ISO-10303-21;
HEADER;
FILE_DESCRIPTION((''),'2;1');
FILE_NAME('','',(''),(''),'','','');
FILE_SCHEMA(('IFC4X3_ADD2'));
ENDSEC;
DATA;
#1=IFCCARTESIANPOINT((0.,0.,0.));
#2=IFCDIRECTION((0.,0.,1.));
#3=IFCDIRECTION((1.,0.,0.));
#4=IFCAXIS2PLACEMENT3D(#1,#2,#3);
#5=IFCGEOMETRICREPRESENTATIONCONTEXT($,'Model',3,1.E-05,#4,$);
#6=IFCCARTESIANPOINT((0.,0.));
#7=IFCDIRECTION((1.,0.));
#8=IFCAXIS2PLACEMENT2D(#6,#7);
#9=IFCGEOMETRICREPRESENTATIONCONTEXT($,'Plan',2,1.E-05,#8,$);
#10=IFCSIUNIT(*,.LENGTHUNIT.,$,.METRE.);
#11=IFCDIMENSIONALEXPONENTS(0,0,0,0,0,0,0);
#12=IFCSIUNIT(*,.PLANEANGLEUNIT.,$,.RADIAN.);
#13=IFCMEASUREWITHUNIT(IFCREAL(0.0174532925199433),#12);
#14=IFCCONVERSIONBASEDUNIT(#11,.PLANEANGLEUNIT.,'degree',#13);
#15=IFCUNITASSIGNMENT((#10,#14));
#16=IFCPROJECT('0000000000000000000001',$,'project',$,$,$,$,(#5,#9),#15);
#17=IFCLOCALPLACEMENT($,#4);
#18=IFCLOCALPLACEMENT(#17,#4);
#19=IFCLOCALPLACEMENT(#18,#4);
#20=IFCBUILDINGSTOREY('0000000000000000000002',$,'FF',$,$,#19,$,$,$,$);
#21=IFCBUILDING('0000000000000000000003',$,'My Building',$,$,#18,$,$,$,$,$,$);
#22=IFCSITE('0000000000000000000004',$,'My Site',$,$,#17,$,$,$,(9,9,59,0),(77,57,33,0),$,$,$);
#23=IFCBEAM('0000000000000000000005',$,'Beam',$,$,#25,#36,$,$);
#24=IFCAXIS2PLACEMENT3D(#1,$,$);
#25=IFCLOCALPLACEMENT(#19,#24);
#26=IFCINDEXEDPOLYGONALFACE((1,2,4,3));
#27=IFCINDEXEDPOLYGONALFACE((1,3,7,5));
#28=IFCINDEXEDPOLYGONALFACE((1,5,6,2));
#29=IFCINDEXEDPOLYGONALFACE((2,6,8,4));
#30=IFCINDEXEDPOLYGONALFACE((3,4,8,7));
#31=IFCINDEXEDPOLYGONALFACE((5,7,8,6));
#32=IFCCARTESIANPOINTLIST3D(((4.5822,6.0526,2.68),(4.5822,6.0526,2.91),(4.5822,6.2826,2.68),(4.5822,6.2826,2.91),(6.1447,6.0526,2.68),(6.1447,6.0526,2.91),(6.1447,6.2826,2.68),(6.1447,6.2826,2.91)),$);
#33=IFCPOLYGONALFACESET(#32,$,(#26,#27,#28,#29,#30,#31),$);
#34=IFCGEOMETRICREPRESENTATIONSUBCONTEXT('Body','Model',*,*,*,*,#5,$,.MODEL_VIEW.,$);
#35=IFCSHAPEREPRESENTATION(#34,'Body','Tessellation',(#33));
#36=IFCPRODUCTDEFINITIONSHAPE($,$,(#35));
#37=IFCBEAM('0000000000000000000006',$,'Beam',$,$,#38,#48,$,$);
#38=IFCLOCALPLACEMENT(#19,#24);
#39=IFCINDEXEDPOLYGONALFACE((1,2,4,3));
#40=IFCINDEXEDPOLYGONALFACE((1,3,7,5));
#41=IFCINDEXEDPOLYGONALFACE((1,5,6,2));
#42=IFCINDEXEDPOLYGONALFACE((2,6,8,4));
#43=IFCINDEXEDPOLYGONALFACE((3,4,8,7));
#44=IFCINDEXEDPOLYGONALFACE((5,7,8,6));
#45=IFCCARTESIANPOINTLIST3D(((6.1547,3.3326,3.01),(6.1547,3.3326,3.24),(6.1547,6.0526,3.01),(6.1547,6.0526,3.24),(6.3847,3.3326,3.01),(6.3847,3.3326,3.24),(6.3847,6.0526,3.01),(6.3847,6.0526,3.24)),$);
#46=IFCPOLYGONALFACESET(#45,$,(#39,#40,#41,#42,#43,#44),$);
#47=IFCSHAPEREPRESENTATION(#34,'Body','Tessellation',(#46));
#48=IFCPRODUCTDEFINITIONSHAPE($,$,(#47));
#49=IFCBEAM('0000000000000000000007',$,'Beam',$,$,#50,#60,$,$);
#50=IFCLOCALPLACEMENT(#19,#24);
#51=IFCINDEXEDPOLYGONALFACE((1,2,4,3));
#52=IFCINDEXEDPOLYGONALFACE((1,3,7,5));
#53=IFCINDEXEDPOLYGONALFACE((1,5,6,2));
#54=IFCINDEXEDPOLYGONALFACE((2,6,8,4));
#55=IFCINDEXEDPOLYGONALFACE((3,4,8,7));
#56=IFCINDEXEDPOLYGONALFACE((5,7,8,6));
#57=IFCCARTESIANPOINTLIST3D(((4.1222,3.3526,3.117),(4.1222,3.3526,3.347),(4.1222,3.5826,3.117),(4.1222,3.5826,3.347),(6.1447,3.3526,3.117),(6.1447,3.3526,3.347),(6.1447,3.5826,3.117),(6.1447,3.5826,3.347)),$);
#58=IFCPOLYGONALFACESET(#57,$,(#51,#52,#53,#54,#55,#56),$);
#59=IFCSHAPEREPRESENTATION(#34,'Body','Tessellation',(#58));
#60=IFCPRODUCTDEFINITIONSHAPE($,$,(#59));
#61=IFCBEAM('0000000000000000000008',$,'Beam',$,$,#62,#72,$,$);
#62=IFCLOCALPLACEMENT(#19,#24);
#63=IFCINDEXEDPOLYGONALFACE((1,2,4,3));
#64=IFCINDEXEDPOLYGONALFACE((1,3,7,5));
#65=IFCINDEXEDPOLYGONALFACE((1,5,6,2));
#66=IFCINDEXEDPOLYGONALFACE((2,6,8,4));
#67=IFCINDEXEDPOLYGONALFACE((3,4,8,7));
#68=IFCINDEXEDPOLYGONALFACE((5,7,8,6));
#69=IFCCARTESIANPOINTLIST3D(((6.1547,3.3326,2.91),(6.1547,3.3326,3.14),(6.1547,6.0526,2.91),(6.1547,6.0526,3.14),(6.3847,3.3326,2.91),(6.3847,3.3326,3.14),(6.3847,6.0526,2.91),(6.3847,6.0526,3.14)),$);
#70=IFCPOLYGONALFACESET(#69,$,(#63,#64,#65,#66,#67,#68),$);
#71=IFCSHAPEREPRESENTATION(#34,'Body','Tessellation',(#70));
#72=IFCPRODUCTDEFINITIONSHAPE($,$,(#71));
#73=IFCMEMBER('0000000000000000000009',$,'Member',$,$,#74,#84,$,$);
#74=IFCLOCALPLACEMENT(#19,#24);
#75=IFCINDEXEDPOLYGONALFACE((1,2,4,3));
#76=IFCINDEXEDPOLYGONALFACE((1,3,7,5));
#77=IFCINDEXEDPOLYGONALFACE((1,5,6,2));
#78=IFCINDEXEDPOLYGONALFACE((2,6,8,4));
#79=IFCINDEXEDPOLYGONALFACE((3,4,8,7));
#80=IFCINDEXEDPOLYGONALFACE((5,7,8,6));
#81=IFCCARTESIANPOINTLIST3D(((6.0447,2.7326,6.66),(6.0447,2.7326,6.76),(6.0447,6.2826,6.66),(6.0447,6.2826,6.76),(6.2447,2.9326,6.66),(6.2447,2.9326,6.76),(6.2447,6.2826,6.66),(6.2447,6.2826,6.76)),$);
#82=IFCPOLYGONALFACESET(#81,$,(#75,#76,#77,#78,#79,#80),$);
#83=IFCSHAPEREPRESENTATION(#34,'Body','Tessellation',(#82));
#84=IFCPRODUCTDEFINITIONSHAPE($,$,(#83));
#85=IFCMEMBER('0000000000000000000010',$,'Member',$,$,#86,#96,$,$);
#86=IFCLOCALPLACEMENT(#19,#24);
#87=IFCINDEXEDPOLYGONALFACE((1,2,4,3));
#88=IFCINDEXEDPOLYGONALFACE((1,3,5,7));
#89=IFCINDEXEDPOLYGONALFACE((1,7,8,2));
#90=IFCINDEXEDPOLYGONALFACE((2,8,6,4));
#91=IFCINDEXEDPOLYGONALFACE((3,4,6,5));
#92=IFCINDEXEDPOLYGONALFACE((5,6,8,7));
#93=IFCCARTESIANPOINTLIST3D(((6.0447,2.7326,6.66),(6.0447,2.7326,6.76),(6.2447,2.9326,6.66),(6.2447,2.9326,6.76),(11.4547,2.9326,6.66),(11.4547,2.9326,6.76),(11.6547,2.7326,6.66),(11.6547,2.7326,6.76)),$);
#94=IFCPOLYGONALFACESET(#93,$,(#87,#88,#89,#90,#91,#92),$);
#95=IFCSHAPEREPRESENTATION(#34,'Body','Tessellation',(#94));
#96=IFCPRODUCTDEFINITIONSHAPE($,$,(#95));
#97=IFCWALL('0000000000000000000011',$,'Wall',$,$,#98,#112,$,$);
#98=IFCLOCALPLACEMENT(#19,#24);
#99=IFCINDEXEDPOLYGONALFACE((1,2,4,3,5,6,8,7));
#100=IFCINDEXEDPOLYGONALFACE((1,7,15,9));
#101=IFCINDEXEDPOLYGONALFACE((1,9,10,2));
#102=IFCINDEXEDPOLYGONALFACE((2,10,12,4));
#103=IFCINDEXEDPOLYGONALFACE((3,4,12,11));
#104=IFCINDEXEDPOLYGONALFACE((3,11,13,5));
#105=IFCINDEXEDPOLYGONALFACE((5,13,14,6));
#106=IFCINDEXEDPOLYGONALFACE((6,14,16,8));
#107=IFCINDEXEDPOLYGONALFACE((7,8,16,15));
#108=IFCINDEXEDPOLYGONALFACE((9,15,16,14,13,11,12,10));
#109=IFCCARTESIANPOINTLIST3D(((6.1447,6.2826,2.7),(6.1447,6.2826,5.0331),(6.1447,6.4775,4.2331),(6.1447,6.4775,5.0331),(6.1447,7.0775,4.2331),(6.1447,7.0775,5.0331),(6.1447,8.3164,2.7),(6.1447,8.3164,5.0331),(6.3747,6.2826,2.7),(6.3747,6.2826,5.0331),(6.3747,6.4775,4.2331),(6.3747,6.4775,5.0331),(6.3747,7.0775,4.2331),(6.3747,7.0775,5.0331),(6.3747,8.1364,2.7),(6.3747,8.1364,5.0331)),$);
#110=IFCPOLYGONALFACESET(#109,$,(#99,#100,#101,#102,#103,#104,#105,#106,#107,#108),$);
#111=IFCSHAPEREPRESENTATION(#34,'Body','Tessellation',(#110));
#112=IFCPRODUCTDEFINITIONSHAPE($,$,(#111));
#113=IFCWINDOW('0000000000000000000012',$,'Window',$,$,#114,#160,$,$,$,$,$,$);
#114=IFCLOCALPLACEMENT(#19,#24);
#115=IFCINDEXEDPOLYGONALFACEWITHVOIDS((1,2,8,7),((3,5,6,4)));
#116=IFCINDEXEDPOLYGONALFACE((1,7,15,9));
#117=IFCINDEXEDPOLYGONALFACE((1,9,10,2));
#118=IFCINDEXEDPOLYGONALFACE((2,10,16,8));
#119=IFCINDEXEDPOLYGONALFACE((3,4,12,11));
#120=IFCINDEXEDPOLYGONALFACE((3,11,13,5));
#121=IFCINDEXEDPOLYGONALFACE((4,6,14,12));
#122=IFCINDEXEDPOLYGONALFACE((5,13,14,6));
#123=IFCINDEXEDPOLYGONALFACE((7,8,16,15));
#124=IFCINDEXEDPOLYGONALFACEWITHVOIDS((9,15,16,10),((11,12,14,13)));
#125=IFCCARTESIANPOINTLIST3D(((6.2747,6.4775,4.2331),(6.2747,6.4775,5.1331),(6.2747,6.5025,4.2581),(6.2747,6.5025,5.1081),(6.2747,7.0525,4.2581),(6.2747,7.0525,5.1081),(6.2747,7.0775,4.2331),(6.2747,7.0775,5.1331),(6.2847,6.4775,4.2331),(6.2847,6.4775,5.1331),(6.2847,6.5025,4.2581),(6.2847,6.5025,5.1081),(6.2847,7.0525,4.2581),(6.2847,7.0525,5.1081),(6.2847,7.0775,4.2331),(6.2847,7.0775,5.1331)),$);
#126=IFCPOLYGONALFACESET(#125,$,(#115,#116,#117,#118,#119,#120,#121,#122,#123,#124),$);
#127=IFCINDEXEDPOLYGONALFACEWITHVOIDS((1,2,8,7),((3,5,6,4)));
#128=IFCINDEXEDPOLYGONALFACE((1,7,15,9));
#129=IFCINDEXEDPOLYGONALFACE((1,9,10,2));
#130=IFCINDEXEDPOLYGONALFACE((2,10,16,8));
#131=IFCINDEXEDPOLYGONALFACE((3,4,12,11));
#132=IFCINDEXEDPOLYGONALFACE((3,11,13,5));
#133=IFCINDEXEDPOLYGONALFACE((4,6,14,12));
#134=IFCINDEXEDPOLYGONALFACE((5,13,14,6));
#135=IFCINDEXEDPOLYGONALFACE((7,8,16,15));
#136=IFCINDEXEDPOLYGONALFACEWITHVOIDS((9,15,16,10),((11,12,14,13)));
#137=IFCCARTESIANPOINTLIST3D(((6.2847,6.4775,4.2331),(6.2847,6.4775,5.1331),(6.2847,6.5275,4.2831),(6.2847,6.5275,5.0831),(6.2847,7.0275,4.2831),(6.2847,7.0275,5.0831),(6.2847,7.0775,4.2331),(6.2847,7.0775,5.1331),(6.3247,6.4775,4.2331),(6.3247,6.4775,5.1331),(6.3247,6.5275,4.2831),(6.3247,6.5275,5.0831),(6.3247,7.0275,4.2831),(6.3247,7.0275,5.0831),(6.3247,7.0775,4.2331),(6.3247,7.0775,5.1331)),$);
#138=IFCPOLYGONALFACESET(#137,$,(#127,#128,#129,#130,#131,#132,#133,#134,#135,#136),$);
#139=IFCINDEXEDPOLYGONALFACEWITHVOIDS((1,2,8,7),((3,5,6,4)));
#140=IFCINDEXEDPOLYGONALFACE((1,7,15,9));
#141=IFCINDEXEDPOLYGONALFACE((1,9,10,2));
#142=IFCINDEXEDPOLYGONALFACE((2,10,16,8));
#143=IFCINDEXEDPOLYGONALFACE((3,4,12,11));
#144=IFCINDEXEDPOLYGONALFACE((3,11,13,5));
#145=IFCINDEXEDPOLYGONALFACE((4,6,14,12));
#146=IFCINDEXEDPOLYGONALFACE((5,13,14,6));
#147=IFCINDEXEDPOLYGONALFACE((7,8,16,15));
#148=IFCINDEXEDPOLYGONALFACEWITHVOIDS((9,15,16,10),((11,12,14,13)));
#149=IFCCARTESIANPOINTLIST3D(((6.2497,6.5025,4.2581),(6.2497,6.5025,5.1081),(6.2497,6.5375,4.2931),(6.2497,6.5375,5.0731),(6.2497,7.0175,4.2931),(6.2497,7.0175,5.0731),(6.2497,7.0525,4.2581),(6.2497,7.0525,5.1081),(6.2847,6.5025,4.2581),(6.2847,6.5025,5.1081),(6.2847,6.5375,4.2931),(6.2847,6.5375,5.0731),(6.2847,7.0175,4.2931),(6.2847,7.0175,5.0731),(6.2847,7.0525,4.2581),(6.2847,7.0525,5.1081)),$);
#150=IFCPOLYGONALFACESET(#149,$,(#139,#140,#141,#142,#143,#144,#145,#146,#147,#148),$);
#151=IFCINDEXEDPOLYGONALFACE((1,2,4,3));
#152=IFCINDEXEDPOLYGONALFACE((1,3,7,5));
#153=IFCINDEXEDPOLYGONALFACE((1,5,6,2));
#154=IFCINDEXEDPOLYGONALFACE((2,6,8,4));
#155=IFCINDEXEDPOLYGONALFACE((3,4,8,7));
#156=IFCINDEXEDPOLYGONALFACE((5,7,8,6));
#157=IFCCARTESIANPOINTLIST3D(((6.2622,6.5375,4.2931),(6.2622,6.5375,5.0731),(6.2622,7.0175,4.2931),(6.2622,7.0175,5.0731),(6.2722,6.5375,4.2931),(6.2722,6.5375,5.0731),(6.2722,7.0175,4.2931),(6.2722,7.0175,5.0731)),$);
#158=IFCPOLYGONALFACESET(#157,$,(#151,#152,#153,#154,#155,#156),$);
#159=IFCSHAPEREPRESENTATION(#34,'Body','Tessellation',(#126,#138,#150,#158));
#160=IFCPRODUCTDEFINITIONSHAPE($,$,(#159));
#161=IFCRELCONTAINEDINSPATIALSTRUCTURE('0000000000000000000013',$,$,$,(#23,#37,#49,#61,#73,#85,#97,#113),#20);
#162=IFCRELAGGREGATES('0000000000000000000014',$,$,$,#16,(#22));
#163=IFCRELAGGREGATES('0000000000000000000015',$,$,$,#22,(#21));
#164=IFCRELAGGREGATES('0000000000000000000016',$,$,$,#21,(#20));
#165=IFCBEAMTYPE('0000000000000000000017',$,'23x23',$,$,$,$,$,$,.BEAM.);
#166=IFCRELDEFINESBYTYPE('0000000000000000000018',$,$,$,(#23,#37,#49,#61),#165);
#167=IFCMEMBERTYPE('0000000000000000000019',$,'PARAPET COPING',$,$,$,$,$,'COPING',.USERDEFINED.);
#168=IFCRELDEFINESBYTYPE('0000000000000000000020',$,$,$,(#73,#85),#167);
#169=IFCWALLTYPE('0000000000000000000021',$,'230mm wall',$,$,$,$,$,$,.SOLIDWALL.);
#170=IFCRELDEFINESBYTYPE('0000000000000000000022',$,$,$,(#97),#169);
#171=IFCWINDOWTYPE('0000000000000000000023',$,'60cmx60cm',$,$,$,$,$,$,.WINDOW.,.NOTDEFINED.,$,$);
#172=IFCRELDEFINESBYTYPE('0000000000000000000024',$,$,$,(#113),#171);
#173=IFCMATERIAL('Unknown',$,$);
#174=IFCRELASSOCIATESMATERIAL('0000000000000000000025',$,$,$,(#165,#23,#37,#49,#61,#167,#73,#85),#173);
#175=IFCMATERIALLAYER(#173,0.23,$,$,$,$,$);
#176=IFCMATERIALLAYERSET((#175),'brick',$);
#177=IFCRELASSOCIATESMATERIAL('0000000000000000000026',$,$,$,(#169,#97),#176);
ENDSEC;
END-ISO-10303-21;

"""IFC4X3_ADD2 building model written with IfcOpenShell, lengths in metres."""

from ifc_helpers import new_model, entity, si_unit, converted_unit, frame, origin_with_axes, origin_2d_with_axis, place, context, subcontext, project, spatial, line, indexed_curve, rectangle, outline, extrude, clip, halfspace, shape, source, transform, mapped, material, layer, layer_set, layer_usage, material_profile, profile_set, profile_usage, type_object, type_shapes, element, fill, save


model = new_model("IFC4X3_ADD2")

# Units and contexts
model_context = context("Model", 3, precision=1e-05, world=origin_with_axes())
plan_context = context("Plan", 2, precision=1e-05, world=origin_2d_with_axis())
body_context_1 = subcontext(model_context, "Body", "Model", "MODEL_VIEW")
body_context_2 = subcontext(plan_context, "Body", "Plan", "PLAN_VIEW")
ifc_project = project(units=[si_unit("LENGTHUNIT", "METRE"), converted_unit("PLANEANGLEUNIT", "degree", entity("IfcReal", 0.0174532925199433), si_unit("PLANEANGLEUNIT", "RADIAN"), dimensions=[0, 0, 0, 0, 0, 0, 0])], contexts=[model_context, plan_context])

# Site, building, storey
site_placement = place(None, origin_with_axes())
site = spatial("IfcSite", under=ifc_project, at=site_placement, Name="My Site", RefLatitude=(9, 9, 59, 0), RefLongitude=(77, 57, 33, 0))
building_placement = place(site_placement, origin_with_axes())
building = spatial("IfcBuilding", under=site, at=building_placement, Name="My Building")
storey_placement = place(building_placement, origin_with_axes())
storey = spatial("IfcBuildingStorey", under=building, at=storey_placement, Name="FF")

# Beams
ifc_material_1 = material(Name="Unknown")
ifc_material_profile_1 = material_profile(ifc_material_1, rectangle(XDim=0.23, YDim=0.23))
ifc_profile_set_1 = profile_set([ifc_material_profile_1])
ifc_profile_usage_1 = profile_usage(ifc_profile_set_1, cardinal=5)
beam_type = type_object("IfcBeamType", Name="23x23", PredefinedType="BEAM", material=ifc_profile_set_1)
beam_1_placement = place(storey_placement, frame((6.1447, 6.1676, 2.795), z_axis=(-1.0, 0.0, 0.0), x_axis=(0.0, -1.0, 0.0)))
element("IfcBeam", 1, at=beam_1_placement, inside=storey, type_object=beam_type, material=ifc_profile_usage_1, Name="Beam", context=body_context_1, shape_type="SweptSolid", body=[
    extrude(rectangle(XDim=0.23, YDim=0.23), origin_with_axes(), (0.0, 0.0, 1.0), 1.5625),
])
ifc_profile_usage_2 = profile_usage(ifc_profile_set_1, cardinal=5)
beam_2_placement = place(storey_placement, frame((6.2697, 3.3326, 3.125), z_axis=(0.0, 1.0, 0.0), x_axis=(-1.0, 0.0, 0.0)))
element("IfcBeam", 2, at=beam_2_placement, inside=storey, type_object=beam_type, material=ifc_profile_usage_2, Name="Beam", context=body_context_1, shape_type="SweptSolid", body=[
    extrude(rectangle(XDim=0.23, YDim=0.23), origin_with_axes(), (0.0, 0.0, 1.0), 2.72),
])
ifc_profile_usage_3 = profile_usage(ifc_profile_set_1, cardinal=5)
beam_3_placement = place(storey_placement, frame((6.1447, 3.4676, 3.232), z_axis=(-1.0, 0.0, 0.0), x_axis=(0.0, -1.0, 0.0)))
element("IfcBeam", 3, at=beam_3_placement, inside=storey, type_object=beam_type, material=ifc_profile_usage_3, Name="Beam", context=body_context_1, shape_type="SweptSolid", body=[
    extrude(rectangle(XDim=0.23, YDim=0.23), origin_with_axes(), (0.0, 0.0, 1.0), 2.0225),
])
ifc_profile_usage_4 = profile_usage(ifc_profile_set_1, cardinal=5)
beam_4_placement = place(storey_placement, frame((6.2697, 3.3326, 3.025), z_axis=(0.0, 1.0, 0.0), x_axis=(-1.0, 0.0, 0.0)))
element("IfcBeam", 4, at=beam_4_placement, inside=storey, type_object=beam_type, material=ifc_profile_usage_4, Name="Beam", context=body_context_1, shape_type="SweptSolid", body=[
    extrude(rectangle(XDim=0.23, YDim=0.23), origin_with_axes(), (0.0, 0.0, 1.0), 2.72),
])

# Members
ifc_material_profile_2 = material_profile(ifc_material_1, rectangle(XDim=0.2, YDim=0.1))
ifc_profile_set_2 = profile_set([ifc_material_profile_2])
ifc_profile_usage_5 = profile_usage(ifc_profile_set_2, cardinal=5)
member_type = type_object("IfcMemberType", Name="PARAPET COPING", ElementType="COPING", PredefinedType="USERDEFINED", material=ifc_profile_set_2)
member_1_placement = place(storey_placement, frame((6.1447, 6.2826, 6.71), z_axis=(0.0, -1.0, 0.0), x_axis=(1.0, 0.0, 0.0)))
element("IfcMember", 5, at=member_1_placement, inside=storey, type_object=member_type, material=ifc_profile_usage_5, Name="Member", context=body_context_1, shape_type="Clipping", body=[
    clip(extrude(rectangle(XDim=0.2, YDim=0.1), origin_with_axes(), (0.0, 0.0, 1.0), 3.55), halfspace(frame((-0.1, -6.66, 3.55), z_axis=(0.707107, 0.0, 0.707107), x_axis=(0.0, -1.0, 0.0)), False)),
])
ifc_profile_usage_6 = profile_usage(ifc_profile_set_2, cardinal=5)
member_2_placement = place(storey_placement, frame((6.0447, 2.8326, 6.71), z_axis=(1.0, 0.0, 0.0), x_axis=(0.0, 1.0, 0.0)))
element("IfcMember", 6, at=member_2_placement, inside=storey, type_object=member_type, material=ifc_profile_usage_6, Name="Member", context=body_context_1, shape_type="Clipping", body=[
    clip(clip(extrude(rectangle(XDim=0.2, YDim=0.1), origin_with_axes(), (0.0, 0.0, 1.0), 5.6101), halfspace(frame((-0.1, -6.66, 5.6101), z_axis=(0.707108, 0.0, 0.707105), x_axis=(0.0, -1.0, 0.0)), False)), halfspace(frame((-0.1, -6.66, 0.0), z_axis=(0.707107, 0.0, -0.707107), x_axis=(0.0, -1.0, 0.0)), False)),
])

# Shared definitions
shared_shape_1 = source(origin_with_axes(), body_context_1, "Body", "SweptSolid", [
    extrude(outline(indexed_curve([(0.0, 0.0), (0.6, 0.0), (0.6, 0.9), (0.0, 0.9)], segments=[line(1, 2, 3, 4, 1)])), frame((0.0, -0.6, 0.0), z_axis=(0.0, -1.0, 0.0), x_axis=(1.0, 0.0, 0.0)), (0.0, 0.0, -1.0), 1.2),
])
window_type_1 = type_object("IfcWindowType", Name="60cmx60cm", PartitioningType="NOTDEFINED", PredefinedType="WINDOW")
shared_shape_2 = source(origin_with_axes(), body_context_1, "Body", "SweptSolid", [
    extrude(outline(indexed_curve([(0.0, 0.0), (0.6, 0.0), (0.6, 0.9), (0.0, 0.9)], segments=[line(1, 2, 3, 4, 1)]), holes=[indexed_curve([(0.025, 0.025), (0.575, 0.025), (0.575, 0.875), (0.025, 0.875)], segments=[line(1, 2, 3, 4, 1)])]), frame((0.0, 0.09, 0.0), z_axis=(0.0, -1.0, 0.0), x_axis=(1.0, 0.0, 0.0)), (0.0, 0.0, -1.0), 0.01),
    extrude(outline(indexed_curve([(0.0, 0.0), (0.6, 0.0), (0.6, 0.9), (0.0, 0.9)], segments=[line(1, 2, 3, 4, 1)]), holes=[indexed_curve([(0.05, 0.05), (0.55, 0.05), (0.55, 0.85), (0.05, 0.85)], segments=[line(1, 2, 3, 4, 1)])]), frame((0.0, 0.05, 0.0), z_axis=(0.0, -1.0, 0.0), x_axis=(1.0, 0.0, 0.0)), (0.0, 0.0, -1.0), 0.04),
    extrude(outline(indexed_curve([(0.0, 0.0), (0.55, 0.0), (0.55, 0.85), (0.0, 0.85)], segments=[line(1, 2, 3, 4, 1)]), holes=[indexed_curve([(0.035, 0.035), (0.515, 0.035), (0.515, 0.815), (0.035, 0.815)], segments=[line(1, 2, 3, 4, 1)])]), frame((0.025, 0.09, 0.025), z_axis=(0.0, -1.0, 0.0), x_axis=(1.0, 0.0, 0.0)), (0.0, 0.0, -1.0), 0.035),
    extrude(outline(indexed_curve([(0.035, 0.035), (0.515, 0.035), (0.515, 0.815), (0.035, 0.815)], segments=[line(1, 2, 3, 4, 1)])), frame((0.025, 0.1025, 0.025), z_axis=(0.0, -1.0, 0.0), x_axis=(1.0, 0.0, 0.0)), (0.0, 0.0, -1.0), 0.01),
])
shared_shape_3 = source(origin_with_axes(), body_context_2, "Body", "Curve2D", [
    entity("IfcIndexedPolyCurve", entity("IfcCartesianPointList2D", [[0.05, 0.05], [0.55, 0.05]])),
    entity("IfcIndexedPolyCurve", entity("IfcCartesianPointList2D", [[0.0, 0.1], [0.025, 0.1], [0.025, 0.09], [0.05, 0.09], [0.05, 0.05], [0.0, 0.05]]), [entity("IfcLineIndex", [1, 2, 3, 4, 5, 6, 1])]),
    entity("IfcIndexedPolyCurve", entity("IfcCartesianPointList2D", [[0.6, 0.1], [0.575, 0.1], [0.575, 0.09], [0.55, 0.09], [0.55, 0.05], [0.6, 0.05]]), [entity("IfcLineIndex", [1, 2, 3, 4, 5, 6, 1])]),
    entity("IfcIndexedPolyCurve", entity("IfcCartesianPointList2D", [[0.025, 0.09], [0.06, 0.09], [0.06, 0.125], [0.025, 0.125]]), [entity("IfcLineIndex", [1, 2, 3, 4, 1])]),
    entity("IfcIndexedPolyCurve", entity("IfcCartesianPointList2D", [[0.575, 0.09], [0.54, 0.09], [0.54, 0.125], [0.575, 0.125]]), [entity("IfcLineIndex", [1, 2, 3, 4, 1])]),
    entity("IfcIndexedPolyCurve", entity("IfcCartesianPointList2D", [[0.06, 0.09], [0.54, 0.09]])),
    entity("IfcIndexedPolyCurve", entity("IfcCartesianPointList2D", [[0.06, 0.125], [0.54, 0.125]])),
    entity("IfcIndexedPolyCurve", entity("IfcCartesianPointList2D", [[0.06, 0.1075], [0.54, 0.1075]])),
])
type_shapes(window_type_1, [shared_shape_2, shared_shape_3])

# Wall, opening, window
ifc_layer_1 = layer(ifc_material_1, 0.23)
ifc_layer_set_1 = layer_set([ifc_layer_1], Name="brick")
ifc_layer_usage_1 = layer_usage(ifc_layer_set_1, "AXIS2", "POSITIVE", 0.0)
wall_type_1 = type_object("IfcWallType", Name="230mm wall", PredefinedType="SOLIDWALL", material=ifc_layer_set_1)
wall_1_placement = place(storey_placement, frame((6.3747, 6.2826, 2.7), z_axis=(0.0, 0.0, 1.0), x_axis=(0.0, 1.0, 0.0)))
wall_1 = element("IfcWall", 7, at=wall_1_placement, inside=storey, type_object=wall_type_1, material=ifc_layer_usage_1, Name="Wall", context=body_context_1, shape_type="SweptSolid", body=[
    extrude(outline(indexed_curve([(0.0, 0.0), (0.0, 0.23), (2.0339, 0.23), (1.8539, 0.0)], segments=[line(1, 2, 3, 4, 1)])), origin_with_axes(), (0.0, 0.0, 1.0), 2.3331),
])
opening_1_placement = place(wall_1_placement, frame((0.1949, 0.0, 1.5331), z_axis=(0.0, 0.0, 1.0), x_axis=(1.0, 0.0, 0.0)))
opening_1 = element("IfcOpeningElement", 8, at=opening_1_placement, cuts=wall_1, PredefinedType="OPENING", context=body_context_1, shape_type="MappedRepresentation", body=[
    mapped(shared_shape_1, transform((0.0, 0.0, 0.0), x_axis=(1.0, 0.0, 0.0), y_axis=(0.0, 1.0, 0.0), z_axis=(0.0, 0.0, 1.0), scale=1.0)),
])
window_1_placement = place(opening_1_placement, frame((0.0, 0.0, 0.0), z_axis=(0.0, 0.0, 1.0), x_axis=(1.0, 0.0, 0.0)))
window_1 = element("IfcWindow", 9, at=window_1_placement, inside=storey, type_object=window_type_1, Name="Window", shapes=[
    shape(body_context_1, "Body", "MappedRepresentation", [mapped(shared_shape_2, transform((0.0, 0.0, 0.0), x_axis=(1.0, 0.0, 0.0), y_axis=(0.0, 1.0, 0.0), z_axis=(0.0, 0.0, 1.0), scale=1.0))]),
    shape(body_context_2, "Body", "MappedRepresentation", [mapped(shared_shape_3, transform((0.0, 0.0, 0.0), x_axis=(1.0, 0.0, 0.0), y_axis=(0.0, 1.0, 0.0), z_axis=(0.0, 0.0, 1.0), scale=1.0))]),
])
fill(opening_1, window_1)

save(model, "model.ifc")
